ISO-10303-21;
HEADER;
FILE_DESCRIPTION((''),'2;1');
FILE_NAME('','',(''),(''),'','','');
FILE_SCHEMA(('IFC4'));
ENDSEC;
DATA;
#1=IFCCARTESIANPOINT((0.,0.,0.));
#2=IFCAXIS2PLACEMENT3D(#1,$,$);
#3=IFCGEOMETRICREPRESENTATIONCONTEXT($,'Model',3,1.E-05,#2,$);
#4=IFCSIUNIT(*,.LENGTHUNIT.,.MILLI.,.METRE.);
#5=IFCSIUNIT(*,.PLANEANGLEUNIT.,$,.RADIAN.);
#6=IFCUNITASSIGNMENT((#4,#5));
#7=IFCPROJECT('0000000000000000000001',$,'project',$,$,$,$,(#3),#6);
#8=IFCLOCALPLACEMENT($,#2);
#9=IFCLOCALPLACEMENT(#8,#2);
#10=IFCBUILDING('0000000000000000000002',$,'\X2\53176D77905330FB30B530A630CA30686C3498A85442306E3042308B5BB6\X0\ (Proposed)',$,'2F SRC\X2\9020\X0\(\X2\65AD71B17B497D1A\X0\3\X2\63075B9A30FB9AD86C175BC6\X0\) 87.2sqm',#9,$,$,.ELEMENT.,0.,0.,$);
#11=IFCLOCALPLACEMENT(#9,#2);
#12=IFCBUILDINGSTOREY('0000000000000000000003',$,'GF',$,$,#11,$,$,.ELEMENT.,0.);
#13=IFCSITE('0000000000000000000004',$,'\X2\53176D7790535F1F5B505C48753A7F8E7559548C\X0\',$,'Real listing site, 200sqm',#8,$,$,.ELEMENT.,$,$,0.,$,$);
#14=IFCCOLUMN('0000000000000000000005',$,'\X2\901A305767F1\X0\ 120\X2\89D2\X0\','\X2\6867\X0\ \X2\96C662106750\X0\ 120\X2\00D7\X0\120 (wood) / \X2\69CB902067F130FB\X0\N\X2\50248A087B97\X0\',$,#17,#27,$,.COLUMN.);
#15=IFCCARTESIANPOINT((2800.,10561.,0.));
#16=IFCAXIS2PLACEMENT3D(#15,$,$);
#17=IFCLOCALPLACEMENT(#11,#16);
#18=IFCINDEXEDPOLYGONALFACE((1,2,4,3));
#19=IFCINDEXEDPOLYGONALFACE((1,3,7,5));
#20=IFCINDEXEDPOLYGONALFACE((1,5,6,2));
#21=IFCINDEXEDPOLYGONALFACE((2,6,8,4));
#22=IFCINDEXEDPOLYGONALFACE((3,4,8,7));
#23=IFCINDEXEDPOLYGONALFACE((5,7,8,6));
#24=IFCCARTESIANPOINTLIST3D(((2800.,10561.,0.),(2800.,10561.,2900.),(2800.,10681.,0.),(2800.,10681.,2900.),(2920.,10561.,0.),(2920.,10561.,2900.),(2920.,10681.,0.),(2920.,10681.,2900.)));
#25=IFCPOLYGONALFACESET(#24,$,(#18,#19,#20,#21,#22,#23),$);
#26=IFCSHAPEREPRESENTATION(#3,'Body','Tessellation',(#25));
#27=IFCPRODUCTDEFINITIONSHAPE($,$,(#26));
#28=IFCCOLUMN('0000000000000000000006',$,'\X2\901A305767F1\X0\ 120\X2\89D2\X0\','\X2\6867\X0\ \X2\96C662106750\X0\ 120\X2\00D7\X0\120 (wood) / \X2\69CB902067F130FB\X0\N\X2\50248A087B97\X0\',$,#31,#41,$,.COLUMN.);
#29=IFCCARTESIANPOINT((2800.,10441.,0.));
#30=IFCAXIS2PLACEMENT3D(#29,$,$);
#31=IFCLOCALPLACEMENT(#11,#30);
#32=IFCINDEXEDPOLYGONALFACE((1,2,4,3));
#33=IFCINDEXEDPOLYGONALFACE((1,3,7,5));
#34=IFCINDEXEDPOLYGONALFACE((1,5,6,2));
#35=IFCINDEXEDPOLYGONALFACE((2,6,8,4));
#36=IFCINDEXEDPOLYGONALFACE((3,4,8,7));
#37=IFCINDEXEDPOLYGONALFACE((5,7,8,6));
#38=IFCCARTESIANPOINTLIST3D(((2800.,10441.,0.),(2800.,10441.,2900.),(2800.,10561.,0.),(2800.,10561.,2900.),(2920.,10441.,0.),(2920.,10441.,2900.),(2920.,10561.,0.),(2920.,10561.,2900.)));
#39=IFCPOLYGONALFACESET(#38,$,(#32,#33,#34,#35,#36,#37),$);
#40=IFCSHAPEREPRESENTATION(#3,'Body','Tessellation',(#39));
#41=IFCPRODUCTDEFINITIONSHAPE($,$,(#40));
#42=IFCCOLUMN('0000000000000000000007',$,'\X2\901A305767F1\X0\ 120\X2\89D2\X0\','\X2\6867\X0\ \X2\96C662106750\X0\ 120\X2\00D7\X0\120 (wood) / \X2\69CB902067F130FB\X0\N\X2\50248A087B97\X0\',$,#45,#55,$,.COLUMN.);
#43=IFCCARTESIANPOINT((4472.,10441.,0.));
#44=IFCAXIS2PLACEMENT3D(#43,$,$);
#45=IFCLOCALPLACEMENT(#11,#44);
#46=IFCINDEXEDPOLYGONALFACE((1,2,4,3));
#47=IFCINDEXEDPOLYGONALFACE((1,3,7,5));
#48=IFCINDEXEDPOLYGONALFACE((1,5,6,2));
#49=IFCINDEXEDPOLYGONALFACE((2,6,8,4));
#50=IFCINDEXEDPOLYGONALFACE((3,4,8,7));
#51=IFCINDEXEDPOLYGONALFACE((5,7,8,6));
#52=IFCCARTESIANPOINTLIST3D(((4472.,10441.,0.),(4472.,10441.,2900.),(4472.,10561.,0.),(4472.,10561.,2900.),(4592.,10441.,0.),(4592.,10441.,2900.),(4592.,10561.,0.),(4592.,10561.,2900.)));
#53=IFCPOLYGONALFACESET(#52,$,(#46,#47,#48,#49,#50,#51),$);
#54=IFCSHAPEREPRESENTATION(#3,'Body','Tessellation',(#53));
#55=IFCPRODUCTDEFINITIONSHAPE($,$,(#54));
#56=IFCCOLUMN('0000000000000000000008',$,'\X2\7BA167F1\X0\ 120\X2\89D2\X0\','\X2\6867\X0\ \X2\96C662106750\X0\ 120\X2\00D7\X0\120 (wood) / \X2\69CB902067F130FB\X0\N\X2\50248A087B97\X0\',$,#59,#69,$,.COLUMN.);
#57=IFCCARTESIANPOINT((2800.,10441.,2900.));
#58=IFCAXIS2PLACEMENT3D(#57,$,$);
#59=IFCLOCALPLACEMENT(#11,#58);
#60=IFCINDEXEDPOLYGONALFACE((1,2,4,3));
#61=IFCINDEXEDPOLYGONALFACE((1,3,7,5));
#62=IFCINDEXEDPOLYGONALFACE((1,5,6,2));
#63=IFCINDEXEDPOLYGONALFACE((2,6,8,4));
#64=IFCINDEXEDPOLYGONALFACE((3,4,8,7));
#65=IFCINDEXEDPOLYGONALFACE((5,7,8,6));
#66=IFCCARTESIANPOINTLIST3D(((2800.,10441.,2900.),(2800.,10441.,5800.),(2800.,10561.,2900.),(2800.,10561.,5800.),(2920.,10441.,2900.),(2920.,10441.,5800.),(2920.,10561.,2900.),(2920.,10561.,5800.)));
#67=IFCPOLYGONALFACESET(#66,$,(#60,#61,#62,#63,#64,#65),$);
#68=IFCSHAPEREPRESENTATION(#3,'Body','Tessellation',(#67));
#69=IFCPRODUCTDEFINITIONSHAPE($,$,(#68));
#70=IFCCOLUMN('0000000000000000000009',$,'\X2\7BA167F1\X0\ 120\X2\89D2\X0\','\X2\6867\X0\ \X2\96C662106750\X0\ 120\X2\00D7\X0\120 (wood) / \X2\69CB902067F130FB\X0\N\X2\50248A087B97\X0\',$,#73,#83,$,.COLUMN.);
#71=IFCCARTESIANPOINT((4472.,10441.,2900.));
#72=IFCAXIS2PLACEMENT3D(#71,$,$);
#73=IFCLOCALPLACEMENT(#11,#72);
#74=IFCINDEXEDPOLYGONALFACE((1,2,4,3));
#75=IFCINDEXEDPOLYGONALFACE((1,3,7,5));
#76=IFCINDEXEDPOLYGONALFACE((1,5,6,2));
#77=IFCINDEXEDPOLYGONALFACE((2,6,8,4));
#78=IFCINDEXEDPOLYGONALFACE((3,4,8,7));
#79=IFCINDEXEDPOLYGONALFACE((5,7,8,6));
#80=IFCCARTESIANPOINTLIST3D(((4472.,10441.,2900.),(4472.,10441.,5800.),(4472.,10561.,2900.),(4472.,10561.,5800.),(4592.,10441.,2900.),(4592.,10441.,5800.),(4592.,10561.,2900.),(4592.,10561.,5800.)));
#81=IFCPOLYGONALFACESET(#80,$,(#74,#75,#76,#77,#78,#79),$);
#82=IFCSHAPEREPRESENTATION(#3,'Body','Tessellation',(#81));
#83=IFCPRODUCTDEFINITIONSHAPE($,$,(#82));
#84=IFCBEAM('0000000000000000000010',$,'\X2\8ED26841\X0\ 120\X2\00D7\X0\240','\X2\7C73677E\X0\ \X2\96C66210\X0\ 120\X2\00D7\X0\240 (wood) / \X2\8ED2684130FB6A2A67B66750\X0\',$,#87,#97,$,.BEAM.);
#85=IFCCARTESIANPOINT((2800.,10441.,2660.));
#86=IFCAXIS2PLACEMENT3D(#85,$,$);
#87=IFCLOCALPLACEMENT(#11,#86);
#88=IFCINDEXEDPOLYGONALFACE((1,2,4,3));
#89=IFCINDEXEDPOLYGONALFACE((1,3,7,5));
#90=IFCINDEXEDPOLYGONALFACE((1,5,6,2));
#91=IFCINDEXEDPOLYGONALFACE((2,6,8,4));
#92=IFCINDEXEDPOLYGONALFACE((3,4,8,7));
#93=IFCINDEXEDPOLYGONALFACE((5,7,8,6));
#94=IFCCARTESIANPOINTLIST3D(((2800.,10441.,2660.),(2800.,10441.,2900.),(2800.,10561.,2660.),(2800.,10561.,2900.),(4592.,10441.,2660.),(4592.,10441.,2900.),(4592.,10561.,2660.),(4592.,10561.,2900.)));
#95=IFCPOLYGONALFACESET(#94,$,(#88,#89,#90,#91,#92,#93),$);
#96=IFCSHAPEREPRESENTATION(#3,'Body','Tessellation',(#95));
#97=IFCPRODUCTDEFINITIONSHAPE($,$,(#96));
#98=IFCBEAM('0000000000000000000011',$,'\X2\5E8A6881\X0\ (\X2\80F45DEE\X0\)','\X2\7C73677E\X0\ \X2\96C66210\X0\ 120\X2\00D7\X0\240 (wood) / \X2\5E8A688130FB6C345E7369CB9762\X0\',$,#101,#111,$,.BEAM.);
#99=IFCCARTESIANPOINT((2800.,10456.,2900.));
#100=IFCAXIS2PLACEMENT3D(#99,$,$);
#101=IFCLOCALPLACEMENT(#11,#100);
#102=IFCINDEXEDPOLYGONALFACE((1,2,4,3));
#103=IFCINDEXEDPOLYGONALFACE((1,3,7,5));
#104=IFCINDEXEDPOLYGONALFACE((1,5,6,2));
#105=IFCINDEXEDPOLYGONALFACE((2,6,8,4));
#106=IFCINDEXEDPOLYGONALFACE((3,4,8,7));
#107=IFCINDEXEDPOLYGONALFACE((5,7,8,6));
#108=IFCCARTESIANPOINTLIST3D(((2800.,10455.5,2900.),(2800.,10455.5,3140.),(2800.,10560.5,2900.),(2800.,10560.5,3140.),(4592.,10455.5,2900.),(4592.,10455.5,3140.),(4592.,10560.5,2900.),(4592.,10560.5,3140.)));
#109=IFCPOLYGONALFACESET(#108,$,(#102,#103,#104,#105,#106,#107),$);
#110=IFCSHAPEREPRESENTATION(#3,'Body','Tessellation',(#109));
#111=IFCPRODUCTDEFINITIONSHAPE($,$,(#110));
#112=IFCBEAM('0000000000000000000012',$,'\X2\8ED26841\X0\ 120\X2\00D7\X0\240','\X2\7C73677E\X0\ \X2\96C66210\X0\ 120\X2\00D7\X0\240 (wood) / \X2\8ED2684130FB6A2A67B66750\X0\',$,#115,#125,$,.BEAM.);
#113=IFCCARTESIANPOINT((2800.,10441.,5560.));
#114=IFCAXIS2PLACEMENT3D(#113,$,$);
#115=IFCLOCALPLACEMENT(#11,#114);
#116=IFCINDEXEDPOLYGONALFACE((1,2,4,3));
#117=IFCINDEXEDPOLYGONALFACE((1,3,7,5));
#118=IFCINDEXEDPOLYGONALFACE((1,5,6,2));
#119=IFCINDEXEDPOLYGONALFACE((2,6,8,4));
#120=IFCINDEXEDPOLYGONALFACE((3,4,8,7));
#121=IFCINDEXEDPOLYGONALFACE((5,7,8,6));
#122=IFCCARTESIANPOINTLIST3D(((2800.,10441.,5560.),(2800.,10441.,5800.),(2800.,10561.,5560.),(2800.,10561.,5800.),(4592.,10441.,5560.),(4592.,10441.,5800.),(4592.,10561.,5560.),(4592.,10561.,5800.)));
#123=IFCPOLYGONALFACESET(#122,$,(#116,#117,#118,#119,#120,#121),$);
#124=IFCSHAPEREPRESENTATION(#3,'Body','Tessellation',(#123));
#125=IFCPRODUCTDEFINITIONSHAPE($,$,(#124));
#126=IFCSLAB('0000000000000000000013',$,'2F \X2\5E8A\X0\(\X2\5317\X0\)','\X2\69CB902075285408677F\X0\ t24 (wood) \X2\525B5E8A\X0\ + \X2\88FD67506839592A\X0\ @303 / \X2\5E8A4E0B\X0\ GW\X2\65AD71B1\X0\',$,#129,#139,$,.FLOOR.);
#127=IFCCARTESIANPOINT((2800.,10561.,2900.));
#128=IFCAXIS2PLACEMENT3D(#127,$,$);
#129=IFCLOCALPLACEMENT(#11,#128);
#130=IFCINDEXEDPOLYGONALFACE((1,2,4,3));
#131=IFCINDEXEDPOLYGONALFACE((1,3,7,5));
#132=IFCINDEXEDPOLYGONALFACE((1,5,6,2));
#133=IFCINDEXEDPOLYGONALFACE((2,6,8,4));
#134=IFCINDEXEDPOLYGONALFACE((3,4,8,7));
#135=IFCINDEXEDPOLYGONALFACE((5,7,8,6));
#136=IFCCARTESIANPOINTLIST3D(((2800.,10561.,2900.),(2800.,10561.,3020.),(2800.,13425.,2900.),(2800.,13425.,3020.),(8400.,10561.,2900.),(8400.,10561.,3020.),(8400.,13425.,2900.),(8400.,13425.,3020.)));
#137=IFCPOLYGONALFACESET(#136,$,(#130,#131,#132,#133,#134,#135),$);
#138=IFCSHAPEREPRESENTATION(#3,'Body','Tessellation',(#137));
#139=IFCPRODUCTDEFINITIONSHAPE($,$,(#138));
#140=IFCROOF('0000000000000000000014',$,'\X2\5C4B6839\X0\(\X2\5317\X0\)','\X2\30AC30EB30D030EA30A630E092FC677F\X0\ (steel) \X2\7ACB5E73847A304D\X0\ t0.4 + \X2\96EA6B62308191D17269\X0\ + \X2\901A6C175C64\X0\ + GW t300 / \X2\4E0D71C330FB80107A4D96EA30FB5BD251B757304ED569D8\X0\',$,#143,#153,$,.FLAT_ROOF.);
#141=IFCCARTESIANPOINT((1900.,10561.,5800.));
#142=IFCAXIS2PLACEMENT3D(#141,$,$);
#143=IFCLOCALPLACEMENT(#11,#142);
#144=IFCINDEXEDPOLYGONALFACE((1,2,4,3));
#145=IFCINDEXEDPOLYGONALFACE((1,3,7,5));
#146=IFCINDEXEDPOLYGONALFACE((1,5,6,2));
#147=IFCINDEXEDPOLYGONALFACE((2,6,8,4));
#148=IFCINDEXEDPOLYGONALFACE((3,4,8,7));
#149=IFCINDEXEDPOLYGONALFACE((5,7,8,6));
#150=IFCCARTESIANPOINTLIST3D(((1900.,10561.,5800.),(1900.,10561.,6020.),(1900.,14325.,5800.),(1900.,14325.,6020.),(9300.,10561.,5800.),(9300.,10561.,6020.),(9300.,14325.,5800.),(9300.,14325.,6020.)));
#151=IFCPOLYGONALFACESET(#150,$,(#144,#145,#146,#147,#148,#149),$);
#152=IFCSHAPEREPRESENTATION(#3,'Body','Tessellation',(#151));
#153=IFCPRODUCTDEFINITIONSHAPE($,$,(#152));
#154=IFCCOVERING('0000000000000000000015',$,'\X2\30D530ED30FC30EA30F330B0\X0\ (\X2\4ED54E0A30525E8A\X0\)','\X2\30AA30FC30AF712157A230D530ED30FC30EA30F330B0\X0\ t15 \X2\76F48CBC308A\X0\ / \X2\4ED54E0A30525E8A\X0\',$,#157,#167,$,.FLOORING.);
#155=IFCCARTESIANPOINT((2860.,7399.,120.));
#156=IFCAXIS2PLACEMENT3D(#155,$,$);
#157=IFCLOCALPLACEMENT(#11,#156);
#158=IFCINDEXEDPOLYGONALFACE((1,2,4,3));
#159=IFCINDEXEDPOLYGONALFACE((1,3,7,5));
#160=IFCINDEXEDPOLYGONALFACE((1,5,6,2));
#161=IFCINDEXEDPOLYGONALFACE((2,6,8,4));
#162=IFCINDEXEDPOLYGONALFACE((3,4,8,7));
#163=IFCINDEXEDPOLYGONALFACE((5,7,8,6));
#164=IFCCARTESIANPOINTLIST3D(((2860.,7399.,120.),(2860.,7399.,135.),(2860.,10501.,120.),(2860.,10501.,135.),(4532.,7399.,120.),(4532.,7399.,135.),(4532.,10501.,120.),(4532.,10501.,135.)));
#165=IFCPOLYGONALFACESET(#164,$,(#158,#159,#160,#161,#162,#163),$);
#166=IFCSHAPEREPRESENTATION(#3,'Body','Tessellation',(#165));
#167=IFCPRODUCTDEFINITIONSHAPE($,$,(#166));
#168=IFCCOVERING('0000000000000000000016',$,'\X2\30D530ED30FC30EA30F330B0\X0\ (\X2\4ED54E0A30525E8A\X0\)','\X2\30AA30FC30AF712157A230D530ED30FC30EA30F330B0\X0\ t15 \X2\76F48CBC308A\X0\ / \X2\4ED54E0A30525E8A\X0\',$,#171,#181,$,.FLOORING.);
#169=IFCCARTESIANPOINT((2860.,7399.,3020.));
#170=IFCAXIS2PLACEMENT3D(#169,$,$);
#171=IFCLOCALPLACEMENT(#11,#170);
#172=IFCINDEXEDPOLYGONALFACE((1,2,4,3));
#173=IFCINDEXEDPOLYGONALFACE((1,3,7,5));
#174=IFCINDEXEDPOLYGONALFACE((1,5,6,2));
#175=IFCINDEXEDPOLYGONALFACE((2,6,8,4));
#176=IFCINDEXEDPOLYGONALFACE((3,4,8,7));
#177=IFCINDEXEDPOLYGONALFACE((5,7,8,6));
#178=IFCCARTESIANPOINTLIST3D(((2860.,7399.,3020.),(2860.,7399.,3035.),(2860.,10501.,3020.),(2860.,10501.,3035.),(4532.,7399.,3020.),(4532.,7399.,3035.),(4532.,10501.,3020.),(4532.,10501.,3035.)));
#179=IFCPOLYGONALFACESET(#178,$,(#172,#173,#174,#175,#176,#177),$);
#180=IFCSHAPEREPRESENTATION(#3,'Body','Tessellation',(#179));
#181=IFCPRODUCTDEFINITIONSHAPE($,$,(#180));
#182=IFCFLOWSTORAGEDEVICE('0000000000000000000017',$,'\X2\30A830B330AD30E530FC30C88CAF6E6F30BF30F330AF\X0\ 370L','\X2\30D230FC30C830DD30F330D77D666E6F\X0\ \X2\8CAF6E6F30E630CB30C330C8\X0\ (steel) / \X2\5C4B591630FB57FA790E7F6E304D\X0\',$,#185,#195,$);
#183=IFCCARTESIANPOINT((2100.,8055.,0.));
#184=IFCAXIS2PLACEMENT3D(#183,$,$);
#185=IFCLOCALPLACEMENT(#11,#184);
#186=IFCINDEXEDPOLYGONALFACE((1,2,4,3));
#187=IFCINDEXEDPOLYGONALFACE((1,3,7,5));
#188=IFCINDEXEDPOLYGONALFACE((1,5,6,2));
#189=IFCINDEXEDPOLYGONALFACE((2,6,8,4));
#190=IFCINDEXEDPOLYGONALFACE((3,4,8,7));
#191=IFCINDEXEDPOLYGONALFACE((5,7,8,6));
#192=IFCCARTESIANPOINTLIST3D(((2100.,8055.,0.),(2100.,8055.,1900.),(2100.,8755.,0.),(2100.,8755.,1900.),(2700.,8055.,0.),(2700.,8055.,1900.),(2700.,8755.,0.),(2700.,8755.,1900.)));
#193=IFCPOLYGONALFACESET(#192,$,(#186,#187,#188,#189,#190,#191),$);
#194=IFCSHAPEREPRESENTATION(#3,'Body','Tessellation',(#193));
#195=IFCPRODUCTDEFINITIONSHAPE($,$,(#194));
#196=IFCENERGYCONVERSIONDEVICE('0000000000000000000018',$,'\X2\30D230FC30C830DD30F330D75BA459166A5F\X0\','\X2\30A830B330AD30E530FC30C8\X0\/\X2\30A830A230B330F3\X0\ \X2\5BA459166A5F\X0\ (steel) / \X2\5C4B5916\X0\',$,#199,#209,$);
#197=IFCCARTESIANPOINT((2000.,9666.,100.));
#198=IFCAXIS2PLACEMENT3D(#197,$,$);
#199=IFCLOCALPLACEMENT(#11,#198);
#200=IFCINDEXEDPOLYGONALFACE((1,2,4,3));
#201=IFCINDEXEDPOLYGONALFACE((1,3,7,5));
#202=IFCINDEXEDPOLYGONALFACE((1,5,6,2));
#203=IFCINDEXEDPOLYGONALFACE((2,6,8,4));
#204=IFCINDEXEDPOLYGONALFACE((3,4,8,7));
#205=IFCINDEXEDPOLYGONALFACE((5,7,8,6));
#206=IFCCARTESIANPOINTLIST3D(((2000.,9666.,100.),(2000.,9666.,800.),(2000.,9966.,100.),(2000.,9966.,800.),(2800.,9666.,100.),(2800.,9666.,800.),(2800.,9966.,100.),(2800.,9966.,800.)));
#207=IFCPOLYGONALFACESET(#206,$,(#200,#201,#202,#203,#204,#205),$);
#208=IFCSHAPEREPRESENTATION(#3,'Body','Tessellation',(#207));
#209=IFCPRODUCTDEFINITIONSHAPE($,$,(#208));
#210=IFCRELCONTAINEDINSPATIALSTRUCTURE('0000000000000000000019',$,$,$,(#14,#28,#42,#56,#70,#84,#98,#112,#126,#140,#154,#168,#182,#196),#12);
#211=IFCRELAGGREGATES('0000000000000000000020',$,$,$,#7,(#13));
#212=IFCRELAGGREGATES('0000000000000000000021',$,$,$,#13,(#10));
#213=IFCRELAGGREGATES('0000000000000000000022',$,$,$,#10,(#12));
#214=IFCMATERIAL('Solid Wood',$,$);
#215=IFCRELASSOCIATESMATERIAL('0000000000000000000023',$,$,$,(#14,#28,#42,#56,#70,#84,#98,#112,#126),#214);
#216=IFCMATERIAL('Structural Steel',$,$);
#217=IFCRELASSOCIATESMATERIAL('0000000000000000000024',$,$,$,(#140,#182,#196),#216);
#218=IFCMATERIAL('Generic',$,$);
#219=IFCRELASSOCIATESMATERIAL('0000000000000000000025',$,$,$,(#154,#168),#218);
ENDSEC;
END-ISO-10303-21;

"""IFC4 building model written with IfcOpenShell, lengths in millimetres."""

from ifc_helpers import new_model, si_unit, frame, frame_2d, origin, place, context, project, spatial, rectangle, extrude, material, element, save


model = new_model("IFC4")

# Units and contexts
model_context = context("Model", 3, precision=1e-05, world=origin())
ifc_project = project(units=[si_unit("LENGTHUNIT", "METRE", prefix="MILLI"), si_unit("PLANEANGLEUNIT", "RADIAN")], contexts=[model_context])

# Site, building, storey
site_placement = place(None, origin())
site = spatial("IfcSite", under=ifc_project, at=site_placement, Name="北海道弟子屈町美留和", ObjectType="Real listing site, 200sqm", CompositionType="ELEMENT", RefElevation=0.0)
building_placement = place(site_placement, origin())
building = spatial("IfcBuilding", under=site, at=building_placement, Name="北海道・サウナと水風呂のある家 (Proposed)", ObjectType="2F SRC造(断熱等級3指定・高気密) 87.2sqm", CompositionType="ELEMENT", ElevationOfRefHeight=0.0, ElevationOfTerrain=0.0)
storey_placement = place(building_placement, origin())
storey = spatial("IfcBuildingStorey", under=building, at=storey_placement, Name="GF", CompositionType="ELEMENT", Elevation=0.0)

# Columns
ifc_material_1 = material(Name="Solid Wood")
column_1_placement = place(storey_placement, frame((2800.0, 10561.0, 0.0)))
element("IfcColumn", 1, at=column_1_placement, inside=storey, material=ifc_material_1, Name="通し柱 120角", Description="桧 集成材 120×120 (wood) / 構造柱・N値計算", PredefinedType="COLUMN", context=model_context, shape_type="SweptSolid", body=[
    extrude(rectangle(XDim=120.0, YDim=120.0, at=frame_2d((60.0, 60.0))), frame((2800.0, 10561.0, 0.0)), (0.0, 0.0, 1.0), 2900.0),
])
column_2_placement = place(storey_placement, frame((2800.0, 10441.0, 0.0)))
element("IfcColumn", 2, at=column_2_placement, inside=storey, material=ifc_material_1, Name="通し柱 120角", Description="桧 集成材 120×120 (wood) / 構造柱・N値計算", PredefinedType="COLUMN", context=model_context, shape_type="SweptSolid", body=[
    extrude(rectangle(XDim=120.0, YDim=120.0, at=frame_2d((60.0, 60.0))), frame((2800.0, 10441.0, 0.0)), (0.0, 0.0, 1.0), 2900.0),
])
column_3_placement = place(storey_placement, frame((4472.0, 10441.0, 0.0)))
element("IfcColumn", 3, at=column_3_placement, inside=storey, material=ifc_material_1, Name="通し柱 120角", Description="桧 集成材 120×120 (wood) / 構造柱・N値計算", PredefinedType="COLUMN", context=model_context, shape_type="SweptSolid", body=[
    extrude(rectangle(XDim=120.0, YDim=120.0, at=frame_2d((60.0, 60.0))), frame((4472.0, 10441.0, 0.0)), (0.0, 0.0, 1.0), 2900.0),
])
column_4_placement = place(storey_placement, frame((2800.0, 10441.0, 2900.0)))
element("IfcColumn", 4, at=column_4_placement, inside=storey, material=ifc_material_1, Name="管柱 120角", Description="桧 集成材 120×120 (wood) / 構造柱・N値計算", PredefinedType="COLUMN", context=model_context, shape_type="SweptSolid", body=[
    extrude(rectangle(XDim=120.0, YDim=120.0, at=frame_2d((60.0, 60.0))), frame((2800.0, 10441.0, 2900.0)), (0.0, 0.0, 1.0), 2900.0),
])
column_5_placement = place(storey_placement, frame((4472.0, 10441.0, 2900.0)))
element("IfcColumn", 5, at=column_5_placement, inside=storey, material=ifc_material_1, Name="管柱 120角", Description="桧 集成材 120×120 (wood) / 構造柱・N値計算", PredefinedType="COLUMN", context=model_context, shape_type="SweptSolid", body=[
    extrude(rectangle(XDim=120.0, YDim=120.0, at=frame_2d((60.0, 60.0))), frame((4472.0, 10441.0, 2900.0)), (0.0, 0.0, 1.0), 2900.0),
])

# Beams
beam_1_placement = place(storey_placement, frame((2800.0, 10441.0, 2660.0)))
element("IfcBeam", 6, at=beam_1_placement, inside=storey, material=ifc_material_1, Name="軒桁 120×240", Description="米松 集成 120×240 (wood) / 軒桁・横架材", PredefinedType="BEAM", context=model_context, shape_type="SweptSolid", body=[
    extrude(rectangle(XDim=1792.0, YDim=120.0, at=frame_2d((896.0, 60.0))), frame((2800.0, 10441.0, 2660.0)), (0.0, 0.0, 1.0), 240.0),
])
beam_2_placement = place(storey_placement, frame((2800.0, 10456.0, 2900.0)))
element("IfcBeam", 7, at=beam_2_placement, inside=storey, material=ifc_material_1, Name="床梁 (胴差)", Description="米松 集成 120×240 (wood) / 床梁・水平構面", PredefinedType="BEAM", context=model_context, shape_type="SweptSolid", body=[
    extrude(rectangle(XDim=1792.0, YDim=105.0, at=frame_2d((896.0, 52.0))), frame((2800.0, 10456.0, 2900.0)), (0.0, 0.0, 1.0), 240.0),
])
beam_3_placement = place(storey_placement, frame((2800.0, 10441.0, 5560.0)))
element("IfcBeam", 8, at=beam_3_placement, inside=storey, material=ifc_material_1, Name="軒桁 120×240", Description="米松 集成 120×240 (wood) / 軒桁・横架材", PredefinedType="BEAM", context=model_context, shape_type="SweptSolid", body=[
    extrude(rectangle(XDim=1792.0, YDim=120.0, at=frame_2d((896.0, 60.0))), frame((2800.0, 10441.0, 5560.0)), (0.0, 0.0, 1.0), 240.0),
])

# Slab
slab_1_placement = place(storey_placement, frame((2800.0, 10561.0, 2900.0)))
element("IfcSlab", 9, at=slab_1_placement, inside=storey, material=ifc_material_1, Name="2F 床(北)", Description="構造用合板 t24 (wood) 剛床 + 製材根太 @303 / 床下 GW断熱", PredefinedType="FLOOR", context=model_context, shape_type="SweptSolid", body=[
    extrude(rectangle(XDim=5600.0, YDim=2864.0, at=frame_2d((2800.0, 1432.0))), frame((2800.0, 10561.0, 2900.0)), (0.0, 0.0, 1.0), 120.0),
])

# Roof
ifc_material_2 = material(Name="Structural Steel")
for number, where, name in (
    (10, (1900.0, 10561.0, 5800.0), "屋根(北)"),
):
    element("IfcRoof", number, at=place(storey_placement, frame(where)), inside=storey, material=ifc_material_2, Name=name, Description="ガルバリウム鋼板 (steel) 立平葺き t0.4 + 雪止め金物 + 通気層 + GW t300 / 不燃・耐積雪・寒冷地仕様", PredefinedType="FLAT_ROOF", context=model_context, shape_type="SweptSolid", body=[
        extrude(rectangle(XDim=7400.0, YDim=3764.0, at=frame_2d((3700.0, 1882.0))), frame((1900.0, 10561.0, 5800.0)), (0.0, 0.0, 1.0), 220.0),
    ])

# Coverings
ifc_material_3 = material(Name="Generic")
covering_1_placement = place(storey_placement, frame((2860.0, 7399.0, 120.0)))
element("IfcCovering", 11, at=covering_1_placement, inside=storey, material=ifc_material_3, Name="フローリング (仕上げ床)", Description="オーク無垢フローリング t15 直貼り / 仕上げ床", PredefinedType="FLOORING", context=model_context, shape_type="SweptSolid", body=[
    extrude(rectangle(XDim=1672.0, YDim=3102.0, at=frame_2d((836.0, 1551.0))), frame((2860.0, 7399.0, 120.0)), (0.0, 0.0, 1.0), 15.0),
])
covering_2_placement = place(storey_placement, frame((2860.0, 7399.0, 3020.0)))
element("IfcCovering", 12, at=covering_2_placement, inside=storey, material=ifc_material_3, Name="フローリング (仕上げ床)", Description="オーク無垢フローリング t15 直貼り / 仕上げ床", PredefinedType="FLOORING", context=model_context, shape_type="SweptSolid", body=[
    extrude(rectangle(XDim=1672.0, YDim=3102.0, at=frame_2d((836.0, 1551.0))), frame((2860.0, 7399.0, 3020.0)), (0.0, 0.0, 1.0), 15.0),
])

# Flow storage device
flow_storage_device_placement = place(storey_placement, frame((2100.0, 8055.0, 0.0)))
element("IfcFlowStorageDevice", 13, at=flow_storage_device_placement, inside=storey, material=ifc_material_2, Name="エコキュート貯湯タンク 370L", Description="ヒートポンプ給湯 貯湯ユニット (steel) / 屋外・基礎置き", context=model_context, shape_type="SweptSolid", body=[
    extrude(rectangle(XDim=600.0, YDim=700.0, at=frame_2d((300.0, 350.0))), frame((2100.0, 8055.0, 0.0)), (0.0, 0.0, 1.0), 1900.0),
])

# Energy conversion device
energy_conversion_device_placement = place(storey_placement, frame((2000.0, 9666.0, 100.0)))
element("IfcEnergyConversionDevice", 14, at=energy_conversion_device_placement, inside=storey, material=ifc_material_2, Name="ヒートポンプ室外機", Description="エコキュート/エアコン 室外機 (steel) / 屋外", context=model_context, shape_type="SweptSolid", body=[
    extrude(rectangle(XDim=800.0, YDim=300.0, at=frame_2d((400.0, 150.0))), frame((2000.0, 9666.0, 100.0)), (0.0, 0.0, 1.0), 700.0),
])

save(model, "model.ifc")
